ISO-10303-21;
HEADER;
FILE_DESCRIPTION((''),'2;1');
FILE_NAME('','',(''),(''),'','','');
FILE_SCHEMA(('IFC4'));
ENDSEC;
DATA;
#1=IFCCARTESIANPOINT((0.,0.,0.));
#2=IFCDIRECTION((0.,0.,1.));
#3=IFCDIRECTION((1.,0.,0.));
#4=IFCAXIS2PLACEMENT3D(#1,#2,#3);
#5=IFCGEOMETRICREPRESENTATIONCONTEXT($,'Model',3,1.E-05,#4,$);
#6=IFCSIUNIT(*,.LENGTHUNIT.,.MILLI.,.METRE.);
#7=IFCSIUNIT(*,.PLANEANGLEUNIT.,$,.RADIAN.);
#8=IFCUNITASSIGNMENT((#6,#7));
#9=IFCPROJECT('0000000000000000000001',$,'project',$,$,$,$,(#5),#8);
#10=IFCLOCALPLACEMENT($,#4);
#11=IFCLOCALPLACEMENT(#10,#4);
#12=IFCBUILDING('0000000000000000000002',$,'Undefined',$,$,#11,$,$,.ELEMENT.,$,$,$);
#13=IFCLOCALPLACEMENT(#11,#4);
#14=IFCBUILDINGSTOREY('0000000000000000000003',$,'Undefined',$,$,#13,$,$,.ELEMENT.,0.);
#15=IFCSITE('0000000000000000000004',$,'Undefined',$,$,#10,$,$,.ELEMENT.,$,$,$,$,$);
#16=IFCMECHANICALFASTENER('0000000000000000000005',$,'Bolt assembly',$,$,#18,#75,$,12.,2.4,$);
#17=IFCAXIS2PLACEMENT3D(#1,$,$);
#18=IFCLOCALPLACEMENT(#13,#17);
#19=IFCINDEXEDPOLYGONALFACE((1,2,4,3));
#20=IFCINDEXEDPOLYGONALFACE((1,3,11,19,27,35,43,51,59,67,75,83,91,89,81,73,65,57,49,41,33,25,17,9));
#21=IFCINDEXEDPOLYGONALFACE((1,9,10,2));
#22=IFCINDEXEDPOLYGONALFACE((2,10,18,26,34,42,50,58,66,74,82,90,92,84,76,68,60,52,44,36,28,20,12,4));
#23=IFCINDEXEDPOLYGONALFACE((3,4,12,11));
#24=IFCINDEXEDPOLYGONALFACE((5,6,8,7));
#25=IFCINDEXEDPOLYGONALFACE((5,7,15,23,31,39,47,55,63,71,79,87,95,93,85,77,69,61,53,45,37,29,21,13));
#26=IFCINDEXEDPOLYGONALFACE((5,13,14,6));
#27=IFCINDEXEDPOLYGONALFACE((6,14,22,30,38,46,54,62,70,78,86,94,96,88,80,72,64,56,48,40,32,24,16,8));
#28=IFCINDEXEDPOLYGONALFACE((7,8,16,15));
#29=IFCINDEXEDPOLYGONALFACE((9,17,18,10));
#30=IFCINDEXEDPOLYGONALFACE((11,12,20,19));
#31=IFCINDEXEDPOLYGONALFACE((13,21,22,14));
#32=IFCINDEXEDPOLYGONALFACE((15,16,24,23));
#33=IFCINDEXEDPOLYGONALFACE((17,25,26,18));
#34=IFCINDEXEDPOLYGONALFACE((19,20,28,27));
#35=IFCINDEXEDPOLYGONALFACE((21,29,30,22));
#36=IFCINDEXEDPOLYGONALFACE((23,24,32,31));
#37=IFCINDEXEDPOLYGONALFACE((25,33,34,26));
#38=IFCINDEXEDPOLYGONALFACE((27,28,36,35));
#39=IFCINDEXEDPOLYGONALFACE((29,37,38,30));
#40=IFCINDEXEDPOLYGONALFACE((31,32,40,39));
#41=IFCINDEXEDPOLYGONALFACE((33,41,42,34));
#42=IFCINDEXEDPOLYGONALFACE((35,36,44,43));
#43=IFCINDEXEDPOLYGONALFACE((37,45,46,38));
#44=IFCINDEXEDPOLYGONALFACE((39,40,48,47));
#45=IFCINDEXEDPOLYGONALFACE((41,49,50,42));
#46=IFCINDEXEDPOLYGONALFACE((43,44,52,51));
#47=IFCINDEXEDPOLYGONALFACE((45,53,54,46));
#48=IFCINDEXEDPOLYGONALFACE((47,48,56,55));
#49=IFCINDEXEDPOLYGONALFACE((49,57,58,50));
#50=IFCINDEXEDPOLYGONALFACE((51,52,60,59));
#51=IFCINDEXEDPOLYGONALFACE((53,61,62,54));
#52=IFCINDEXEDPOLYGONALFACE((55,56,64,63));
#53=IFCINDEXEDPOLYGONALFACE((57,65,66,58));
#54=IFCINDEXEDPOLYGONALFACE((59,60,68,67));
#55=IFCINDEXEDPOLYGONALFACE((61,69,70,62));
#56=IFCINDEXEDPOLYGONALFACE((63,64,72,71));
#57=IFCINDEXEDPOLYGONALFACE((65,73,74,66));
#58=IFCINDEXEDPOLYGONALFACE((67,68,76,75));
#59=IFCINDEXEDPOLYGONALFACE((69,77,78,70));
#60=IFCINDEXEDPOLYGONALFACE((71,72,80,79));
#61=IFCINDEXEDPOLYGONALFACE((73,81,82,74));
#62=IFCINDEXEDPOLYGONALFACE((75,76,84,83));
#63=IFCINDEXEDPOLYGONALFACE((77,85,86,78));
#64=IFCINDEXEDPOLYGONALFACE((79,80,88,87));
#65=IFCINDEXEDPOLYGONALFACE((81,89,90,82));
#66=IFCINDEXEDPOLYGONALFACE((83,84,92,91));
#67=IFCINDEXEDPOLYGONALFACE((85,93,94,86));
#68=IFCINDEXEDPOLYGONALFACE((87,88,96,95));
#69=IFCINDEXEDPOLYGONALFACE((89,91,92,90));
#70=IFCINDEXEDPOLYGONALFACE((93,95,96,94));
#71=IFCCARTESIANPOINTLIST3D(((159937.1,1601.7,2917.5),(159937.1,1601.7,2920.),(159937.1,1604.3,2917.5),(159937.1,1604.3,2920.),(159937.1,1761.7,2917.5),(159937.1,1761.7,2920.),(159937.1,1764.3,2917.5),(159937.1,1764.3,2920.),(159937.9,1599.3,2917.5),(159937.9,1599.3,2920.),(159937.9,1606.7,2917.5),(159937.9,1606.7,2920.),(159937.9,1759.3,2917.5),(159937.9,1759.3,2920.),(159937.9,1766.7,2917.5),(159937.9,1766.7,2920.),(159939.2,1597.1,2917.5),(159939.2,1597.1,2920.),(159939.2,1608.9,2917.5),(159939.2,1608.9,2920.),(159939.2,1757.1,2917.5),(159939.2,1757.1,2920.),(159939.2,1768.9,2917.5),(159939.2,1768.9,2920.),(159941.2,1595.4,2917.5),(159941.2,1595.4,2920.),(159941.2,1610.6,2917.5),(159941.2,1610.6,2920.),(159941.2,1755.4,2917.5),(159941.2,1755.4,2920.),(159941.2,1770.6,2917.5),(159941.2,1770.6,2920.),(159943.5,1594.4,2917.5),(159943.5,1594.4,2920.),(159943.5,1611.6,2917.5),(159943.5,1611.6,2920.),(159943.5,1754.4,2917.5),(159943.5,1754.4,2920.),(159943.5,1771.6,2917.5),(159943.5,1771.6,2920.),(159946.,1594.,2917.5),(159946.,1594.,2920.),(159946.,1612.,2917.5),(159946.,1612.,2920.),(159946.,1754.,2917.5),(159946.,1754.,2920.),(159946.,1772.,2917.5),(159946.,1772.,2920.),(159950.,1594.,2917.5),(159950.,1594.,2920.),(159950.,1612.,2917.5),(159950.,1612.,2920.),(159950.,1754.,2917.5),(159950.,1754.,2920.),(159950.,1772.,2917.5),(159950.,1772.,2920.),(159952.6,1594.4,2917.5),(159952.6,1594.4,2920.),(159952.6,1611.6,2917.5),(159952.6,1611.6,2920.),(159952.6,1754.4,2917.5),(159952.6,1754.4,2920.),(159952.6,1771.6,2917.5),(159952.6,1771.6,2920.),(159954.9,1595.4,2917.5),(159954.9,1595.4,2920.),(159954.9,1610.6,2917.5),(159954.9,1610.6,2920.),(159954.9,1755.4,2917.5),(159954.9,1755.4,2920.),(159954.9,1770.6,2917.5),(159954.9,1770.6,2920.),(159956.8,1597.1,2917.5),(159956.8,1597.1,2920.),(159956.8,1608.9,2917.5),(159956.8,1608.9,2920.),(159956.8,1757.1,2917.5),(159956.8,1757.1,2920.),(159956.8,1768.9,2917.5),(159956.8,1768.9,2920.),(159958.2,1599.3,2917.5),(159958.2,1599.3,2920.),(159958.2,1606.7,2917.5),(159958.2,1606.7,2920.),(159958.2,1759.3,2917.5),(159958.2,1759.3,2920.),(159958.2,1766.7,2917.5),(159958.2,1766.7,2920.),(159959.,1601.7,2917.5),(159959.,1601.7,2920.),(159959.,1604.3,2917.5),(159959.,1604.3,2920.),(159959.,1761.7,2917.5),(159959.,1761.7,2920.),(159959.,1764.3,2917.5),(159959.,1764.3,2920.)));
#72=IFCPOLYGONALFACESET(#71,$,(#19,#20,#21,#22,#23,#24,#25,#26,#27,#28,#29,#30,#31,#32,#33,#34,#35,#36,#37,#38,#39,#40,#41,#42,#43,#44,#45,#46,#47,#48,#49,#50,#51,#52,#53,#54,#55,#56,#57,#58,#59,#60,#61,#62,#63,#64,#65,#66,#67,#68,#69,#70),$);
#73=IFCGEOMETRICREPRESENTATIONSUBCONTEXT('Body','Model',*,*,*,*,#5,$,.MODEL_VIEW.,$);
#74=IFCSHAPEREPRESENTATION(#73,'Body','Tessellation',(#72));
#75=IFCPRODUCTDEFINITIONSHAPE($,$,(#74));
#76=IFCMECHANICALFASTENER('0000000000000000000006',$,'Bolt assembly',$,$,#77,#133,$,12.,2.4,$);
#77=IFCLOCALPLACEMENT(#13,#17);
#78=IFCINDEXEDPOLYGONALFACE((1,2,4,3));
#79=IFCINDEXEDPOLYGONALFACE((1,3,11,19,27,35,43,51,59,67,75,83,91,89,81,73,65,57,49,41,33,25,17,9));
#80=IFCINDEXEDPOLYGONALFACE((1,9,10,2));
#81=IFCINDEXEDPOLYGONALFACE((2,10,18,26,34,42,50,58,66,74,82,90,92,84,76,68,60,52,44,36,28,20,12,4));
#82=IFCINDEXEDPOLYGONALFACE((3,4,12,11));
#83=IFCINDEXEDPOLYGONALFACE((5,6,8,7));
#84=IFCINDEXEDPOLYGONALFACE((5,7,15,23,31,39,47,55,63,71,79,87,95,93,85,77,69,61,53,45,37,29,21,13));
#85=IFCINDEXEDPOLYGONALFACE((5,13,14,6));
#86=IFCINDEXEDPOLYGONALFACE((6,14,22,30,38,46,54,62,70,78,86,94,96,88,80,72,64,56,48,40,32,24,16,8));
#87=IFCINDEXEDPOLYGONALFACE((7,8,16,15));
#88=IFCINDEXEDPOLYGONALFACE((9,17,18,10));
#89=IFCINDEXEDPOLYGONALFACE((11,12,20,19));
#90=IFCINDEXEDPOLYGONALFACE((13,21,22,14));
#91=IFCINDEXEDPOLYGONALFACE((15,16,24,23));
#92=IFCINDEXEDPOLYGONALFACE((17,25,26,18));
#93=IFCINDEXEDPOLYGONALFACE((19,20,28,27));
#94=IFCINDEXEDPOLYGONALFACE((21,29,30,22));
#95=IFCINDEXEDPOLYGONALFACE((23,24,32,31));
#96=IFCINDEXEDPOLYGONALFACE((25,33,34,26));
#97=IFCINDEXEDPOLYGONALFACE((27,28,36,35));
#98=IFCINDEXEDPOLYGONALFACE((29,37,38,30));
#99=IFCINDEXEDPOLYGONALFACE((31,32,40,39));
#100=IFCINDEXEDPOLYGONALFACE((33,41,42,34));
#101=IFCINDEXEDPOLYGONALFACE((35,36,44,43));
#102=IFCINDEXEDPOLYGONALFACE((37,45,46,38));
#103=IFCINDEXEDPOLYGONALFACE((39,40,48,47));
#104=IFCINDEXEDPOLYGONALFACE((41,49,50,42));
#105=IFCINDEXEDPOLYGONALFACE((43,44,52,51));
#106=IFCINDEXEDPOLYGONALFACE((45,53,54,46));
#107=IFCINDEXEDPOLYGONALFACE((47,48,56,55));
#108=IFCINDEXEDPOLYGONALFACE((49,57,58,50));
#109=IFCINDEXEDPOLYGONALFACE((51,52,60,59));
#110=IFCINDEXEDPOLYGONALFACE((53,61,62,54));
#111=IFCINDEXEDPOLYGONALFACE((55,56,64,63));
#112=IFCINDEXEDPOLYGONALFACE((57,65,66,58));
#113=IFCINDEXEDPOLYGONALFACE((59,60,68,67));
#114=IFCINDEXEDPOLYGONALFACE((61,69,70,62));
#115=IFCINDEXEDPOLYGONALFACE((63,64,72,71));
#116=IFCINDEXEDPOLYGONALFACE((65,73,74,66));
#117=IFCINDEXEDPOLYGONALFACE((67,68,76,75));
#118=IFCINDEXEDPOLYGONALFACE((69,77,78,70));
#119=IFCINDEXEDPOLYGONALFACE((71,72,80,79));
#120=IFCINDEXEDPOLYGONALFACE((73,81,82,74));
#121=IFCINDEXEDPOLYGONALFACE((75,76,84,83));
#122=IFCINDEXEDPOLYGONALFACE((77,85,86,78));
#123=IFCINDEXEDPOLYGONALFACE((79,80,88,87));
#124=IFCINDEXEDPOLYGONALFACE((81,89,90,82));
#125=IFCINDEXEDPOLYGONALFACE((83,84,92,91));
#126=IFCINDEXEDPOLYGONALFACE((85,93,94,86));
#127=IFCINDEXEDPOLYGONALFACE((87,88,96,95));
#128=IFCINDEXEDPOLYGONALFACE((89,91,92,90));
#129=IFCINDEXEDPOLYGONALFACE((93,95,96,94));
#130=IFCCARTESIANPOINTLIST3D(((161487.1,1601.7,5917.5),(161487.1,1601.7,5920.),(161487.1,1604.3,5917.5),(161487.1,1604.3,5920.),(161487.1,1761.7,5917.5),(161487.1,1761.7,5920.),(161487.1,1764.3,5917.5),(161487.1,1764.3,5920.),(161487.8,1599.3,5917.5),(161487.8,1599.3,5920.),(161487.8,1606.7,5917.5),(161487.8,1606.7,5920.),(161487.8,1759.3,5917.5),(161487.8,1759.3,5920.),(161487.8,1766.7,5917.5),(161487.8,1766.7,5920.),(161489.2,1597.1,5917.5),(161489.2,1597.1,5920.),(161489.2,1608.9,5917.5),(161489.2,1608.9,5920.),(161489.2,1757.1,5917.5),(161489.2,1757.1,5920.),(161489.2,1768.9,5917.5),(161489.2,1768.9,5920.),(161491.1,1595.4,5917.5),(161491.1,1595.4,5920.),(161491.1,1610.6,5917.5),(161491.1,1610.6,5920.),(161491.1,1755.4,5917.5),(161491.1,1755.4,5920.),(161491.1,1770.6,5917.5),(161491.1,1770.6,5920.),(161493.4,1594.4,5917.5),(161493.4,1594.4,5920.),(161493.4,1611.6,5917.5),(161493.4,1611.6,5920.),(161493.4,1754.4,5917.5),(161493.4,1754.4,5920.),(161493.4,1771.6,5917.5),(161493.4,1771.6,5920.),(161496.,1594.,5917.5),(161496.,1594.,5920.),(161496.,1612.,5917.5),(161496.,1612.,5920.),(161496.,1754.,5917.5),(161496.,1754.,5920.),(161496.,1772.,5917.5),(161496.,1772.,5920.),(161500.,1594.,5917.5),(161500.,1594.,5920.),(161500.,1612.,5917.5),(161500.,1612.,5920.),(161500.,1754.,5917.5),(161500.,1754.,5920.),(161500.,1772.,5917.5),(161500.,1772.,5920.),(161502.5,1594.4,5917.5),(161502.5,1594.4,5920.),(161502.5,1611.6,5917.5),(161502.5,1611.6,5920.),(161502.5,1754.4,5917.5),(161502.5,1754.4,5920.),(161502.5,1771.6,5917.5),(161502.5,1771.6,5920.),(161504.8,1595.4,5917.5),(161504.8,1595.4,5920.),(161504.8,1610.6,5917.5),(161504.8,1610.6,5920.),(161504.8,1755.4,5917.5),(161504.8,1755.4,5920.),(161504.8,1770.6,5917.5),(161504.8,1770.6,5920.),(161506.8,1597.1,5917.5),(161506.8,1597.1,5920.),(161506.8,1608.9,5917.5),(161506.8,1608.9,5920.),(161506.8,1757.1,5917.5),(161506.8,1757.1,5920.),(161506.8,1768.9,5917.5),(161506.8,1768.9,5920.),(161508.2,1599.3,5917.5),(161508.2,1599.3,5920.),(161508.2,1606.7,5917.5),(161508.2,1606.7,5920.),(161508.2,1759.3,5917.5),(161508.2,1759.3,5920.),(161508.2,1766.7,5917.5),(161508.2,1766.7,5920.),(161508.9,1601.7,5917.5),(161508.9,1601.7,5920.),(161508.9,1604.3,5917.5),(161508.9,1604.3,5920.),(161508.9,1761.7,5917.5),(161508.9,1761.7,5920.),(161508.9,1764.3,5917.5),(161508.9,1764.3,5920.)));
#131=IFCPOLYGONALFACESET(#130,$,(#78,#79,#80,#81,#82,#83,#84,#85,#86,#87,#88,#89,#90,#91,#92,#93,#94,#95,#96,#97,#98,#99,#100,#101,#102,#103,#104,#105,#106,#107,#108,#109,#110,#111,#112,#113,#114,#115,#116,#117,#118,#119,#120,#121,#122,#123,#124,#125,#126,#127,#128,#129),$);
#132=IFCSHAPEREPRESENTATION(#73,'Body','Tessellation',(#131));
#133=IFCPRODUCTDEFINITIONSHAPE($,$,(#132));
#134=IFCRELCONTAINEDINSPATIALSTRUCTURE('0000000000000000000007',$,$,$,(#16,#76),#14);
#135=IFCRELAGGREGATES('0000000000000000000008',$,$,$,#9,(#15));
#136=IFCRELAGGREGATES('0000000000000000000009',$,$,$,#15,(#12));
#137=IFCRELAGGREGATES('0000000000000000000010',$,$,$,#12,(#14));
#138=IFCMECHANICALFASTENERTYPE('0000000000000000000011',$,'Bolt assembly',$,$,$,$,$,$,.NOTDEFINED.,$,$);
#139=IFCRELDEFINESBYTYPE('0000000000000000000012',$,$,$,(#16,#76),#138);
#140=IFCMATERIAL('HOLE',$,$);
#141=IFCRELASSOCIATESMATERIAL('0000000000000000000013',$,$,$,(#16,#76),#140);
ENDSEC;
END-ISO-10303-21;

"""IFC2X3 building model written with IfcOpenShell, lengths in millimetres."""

from ifc_helpers import new_model, si_unit, frame, frame_2d, origin_with_axes, place, context, subcontext, project, spatial, polyline, circle_curve, parameter, trimmed, segment, composite_curve, outline, extrude, source, transform, mapped, material, type_object, element, save


model = new_model("IFC2X3")

# Units and contexts
model_context = context("Model", 3, precision=1e-05, world=origin_with_axes())
body_context = subcontext(model_context, "Body", "Model", "MODEL_VIEW")
ifc_project = project(units=[si_unit("LENGTHUNIT", "METRE", prefix="MILLI"), si_unit("PLANEANGLEUNIT", "RADIAN")], contexts=[model_context])

# Site, building, storey
site_placement = place(None, origin_with_axes())
site = spatial("IfcSite", under=ifc_project, at=site_placement, Name="Undefined", CompositionType="ELEMENT")
building_placement = place(site_placement, origin_with_axes())
building = spatial("IfcBuilding", under=site, at=building_placement, Name="Undefined", CompositionType="ELEMENT")
storey_placement = place(building_placement, origin_with_axes())
storey = spatial("IfcBuildingStorey", under=building, at=storey_placement, Name="Undefined", CompositionType="ELEMENT", Elevation=0.0)

# Mechanical fasteners
ifc_material_1 = material(Name="HOLE")
mechanical_fastener_type = type_object("IfcMechanicalFastenerType", Name="Bolt assembly")
shared_shape_1 = source(origin_with_axes(), body_context, "Body", "SweptSolid", [
    extrude(outline(composite_curve([segment(polyline([(-2.0, 9.0), (2.0, 9.0)]), True, "CONTINUOUS"), segment(trimmed(circle_curve(frame_2d((2.0, 0.0), x_axis=(0.0, 1.0)), 9.0), [parameter(0.0)], [parameter(3.141593)], False, "PARAMETER"), True, "CONTINUOUS"), segment(polyline([(2.0, -9.0), (-2.0, -9.0)]), True, "CONTINUOUS"), segment(trimmed(circle_curve(frame_2d((-2.0, 0.0), x_axis=(0.0, -1.0)), 9.0), [parameter(0.0)], [parameter(3.141593)], False, "PARAMETER"), True, "DISCONTINUOUS")], self_intersect=False)), frame((0.0, -2.4, 0.0), z_axis=(0.0, 1.0, 0.0), x_axis=(1.0, 0.0, 0.0)), (0.0, 0.0, 1.0), 2.5),
])
mechanical_fastener_1_placement = place(storey_placement, frame((159948.0, 1683.0, 2917.6), z_axis=(0.0, -1.0, 0.0), x_axis=(-1.0, 0.0, 0.0)))
element("IfcMechanicalFastener", 1, at=mechanical_fastener_1_placement, inside=storey, type_object=mechanical_fastener_type, material=ifc_material_1, Name="Bolt assembly", NominalDiameter=12.0, NominalLength=2.4, context=body_context, shape_type="MappedRepresentation", body=[
    mapped(shared_shape_1, transform((0.0, 0.0, -80.0))),
    mapped(shared_shape_1, transform((0.0, 0.0, 80.0))),
])
shared_shape_2 = source(origin_with_axes(), body_context, "Body", "SweptSolid", [
    extrude(outline(composite_curve([segment(polyline([(-2.0, 9.0), (2.0, 9.0)]), True, "CONTINUOUS"), segment(trimmed(circle_curve(frame_2d((2.0, 0.0), x_axis=(0.0, 1.0)), 9.0), [parameter(0.0)], [parameter(3.141593)], False, "PARAMETER"), True, "CONTINUOUS"), segment(polyline([(2.0, -9.0), (-2.0, -9.0)]), True, "CONTINUOUS"), segment(trimmed(circle_curve(frame_2d((-2.0, 0.0), x_axis=(0.0, -1.0)), 9.0), [parameter(0.0)], [parameter(3.141593)], False, "PARAMETER"), True, "DISCONTINUOUS")], self_intersect=False)), frame((0.0, -2.4, 0.0), z_axis=(0.0, 1.0, 0.0), x_axis=(1.0, 0.0, 0.0)), (0.0, 0.0, 1.0), 2.5),
])
mechanical_fastener_2_placement = place(storey_placement, frame((161498.0, 1683.0, 5917.6), z_axis=(0.0, -1.0, 0.0), x_axis=(-1.0, 0.0, 0.0)))
element("IfcMechanicalFastener", 2, at=mechanical_fastener_2_placement, inside=storey, type_object=mechanical_fastener_type, material=ifc_material_1, Name="Bolt assembly", NominalDiameter=12.0, NominalLength=2.4, context=body_context, shape_type="MappedRepresentation", body=[
    mapped(shared_shape_2, transform((0.0, 0.0, -80.0))),
    mapped(shared_shape_2, transform((0.0, 0.0, 80.0))),
])

save(model, "model.ifc")
